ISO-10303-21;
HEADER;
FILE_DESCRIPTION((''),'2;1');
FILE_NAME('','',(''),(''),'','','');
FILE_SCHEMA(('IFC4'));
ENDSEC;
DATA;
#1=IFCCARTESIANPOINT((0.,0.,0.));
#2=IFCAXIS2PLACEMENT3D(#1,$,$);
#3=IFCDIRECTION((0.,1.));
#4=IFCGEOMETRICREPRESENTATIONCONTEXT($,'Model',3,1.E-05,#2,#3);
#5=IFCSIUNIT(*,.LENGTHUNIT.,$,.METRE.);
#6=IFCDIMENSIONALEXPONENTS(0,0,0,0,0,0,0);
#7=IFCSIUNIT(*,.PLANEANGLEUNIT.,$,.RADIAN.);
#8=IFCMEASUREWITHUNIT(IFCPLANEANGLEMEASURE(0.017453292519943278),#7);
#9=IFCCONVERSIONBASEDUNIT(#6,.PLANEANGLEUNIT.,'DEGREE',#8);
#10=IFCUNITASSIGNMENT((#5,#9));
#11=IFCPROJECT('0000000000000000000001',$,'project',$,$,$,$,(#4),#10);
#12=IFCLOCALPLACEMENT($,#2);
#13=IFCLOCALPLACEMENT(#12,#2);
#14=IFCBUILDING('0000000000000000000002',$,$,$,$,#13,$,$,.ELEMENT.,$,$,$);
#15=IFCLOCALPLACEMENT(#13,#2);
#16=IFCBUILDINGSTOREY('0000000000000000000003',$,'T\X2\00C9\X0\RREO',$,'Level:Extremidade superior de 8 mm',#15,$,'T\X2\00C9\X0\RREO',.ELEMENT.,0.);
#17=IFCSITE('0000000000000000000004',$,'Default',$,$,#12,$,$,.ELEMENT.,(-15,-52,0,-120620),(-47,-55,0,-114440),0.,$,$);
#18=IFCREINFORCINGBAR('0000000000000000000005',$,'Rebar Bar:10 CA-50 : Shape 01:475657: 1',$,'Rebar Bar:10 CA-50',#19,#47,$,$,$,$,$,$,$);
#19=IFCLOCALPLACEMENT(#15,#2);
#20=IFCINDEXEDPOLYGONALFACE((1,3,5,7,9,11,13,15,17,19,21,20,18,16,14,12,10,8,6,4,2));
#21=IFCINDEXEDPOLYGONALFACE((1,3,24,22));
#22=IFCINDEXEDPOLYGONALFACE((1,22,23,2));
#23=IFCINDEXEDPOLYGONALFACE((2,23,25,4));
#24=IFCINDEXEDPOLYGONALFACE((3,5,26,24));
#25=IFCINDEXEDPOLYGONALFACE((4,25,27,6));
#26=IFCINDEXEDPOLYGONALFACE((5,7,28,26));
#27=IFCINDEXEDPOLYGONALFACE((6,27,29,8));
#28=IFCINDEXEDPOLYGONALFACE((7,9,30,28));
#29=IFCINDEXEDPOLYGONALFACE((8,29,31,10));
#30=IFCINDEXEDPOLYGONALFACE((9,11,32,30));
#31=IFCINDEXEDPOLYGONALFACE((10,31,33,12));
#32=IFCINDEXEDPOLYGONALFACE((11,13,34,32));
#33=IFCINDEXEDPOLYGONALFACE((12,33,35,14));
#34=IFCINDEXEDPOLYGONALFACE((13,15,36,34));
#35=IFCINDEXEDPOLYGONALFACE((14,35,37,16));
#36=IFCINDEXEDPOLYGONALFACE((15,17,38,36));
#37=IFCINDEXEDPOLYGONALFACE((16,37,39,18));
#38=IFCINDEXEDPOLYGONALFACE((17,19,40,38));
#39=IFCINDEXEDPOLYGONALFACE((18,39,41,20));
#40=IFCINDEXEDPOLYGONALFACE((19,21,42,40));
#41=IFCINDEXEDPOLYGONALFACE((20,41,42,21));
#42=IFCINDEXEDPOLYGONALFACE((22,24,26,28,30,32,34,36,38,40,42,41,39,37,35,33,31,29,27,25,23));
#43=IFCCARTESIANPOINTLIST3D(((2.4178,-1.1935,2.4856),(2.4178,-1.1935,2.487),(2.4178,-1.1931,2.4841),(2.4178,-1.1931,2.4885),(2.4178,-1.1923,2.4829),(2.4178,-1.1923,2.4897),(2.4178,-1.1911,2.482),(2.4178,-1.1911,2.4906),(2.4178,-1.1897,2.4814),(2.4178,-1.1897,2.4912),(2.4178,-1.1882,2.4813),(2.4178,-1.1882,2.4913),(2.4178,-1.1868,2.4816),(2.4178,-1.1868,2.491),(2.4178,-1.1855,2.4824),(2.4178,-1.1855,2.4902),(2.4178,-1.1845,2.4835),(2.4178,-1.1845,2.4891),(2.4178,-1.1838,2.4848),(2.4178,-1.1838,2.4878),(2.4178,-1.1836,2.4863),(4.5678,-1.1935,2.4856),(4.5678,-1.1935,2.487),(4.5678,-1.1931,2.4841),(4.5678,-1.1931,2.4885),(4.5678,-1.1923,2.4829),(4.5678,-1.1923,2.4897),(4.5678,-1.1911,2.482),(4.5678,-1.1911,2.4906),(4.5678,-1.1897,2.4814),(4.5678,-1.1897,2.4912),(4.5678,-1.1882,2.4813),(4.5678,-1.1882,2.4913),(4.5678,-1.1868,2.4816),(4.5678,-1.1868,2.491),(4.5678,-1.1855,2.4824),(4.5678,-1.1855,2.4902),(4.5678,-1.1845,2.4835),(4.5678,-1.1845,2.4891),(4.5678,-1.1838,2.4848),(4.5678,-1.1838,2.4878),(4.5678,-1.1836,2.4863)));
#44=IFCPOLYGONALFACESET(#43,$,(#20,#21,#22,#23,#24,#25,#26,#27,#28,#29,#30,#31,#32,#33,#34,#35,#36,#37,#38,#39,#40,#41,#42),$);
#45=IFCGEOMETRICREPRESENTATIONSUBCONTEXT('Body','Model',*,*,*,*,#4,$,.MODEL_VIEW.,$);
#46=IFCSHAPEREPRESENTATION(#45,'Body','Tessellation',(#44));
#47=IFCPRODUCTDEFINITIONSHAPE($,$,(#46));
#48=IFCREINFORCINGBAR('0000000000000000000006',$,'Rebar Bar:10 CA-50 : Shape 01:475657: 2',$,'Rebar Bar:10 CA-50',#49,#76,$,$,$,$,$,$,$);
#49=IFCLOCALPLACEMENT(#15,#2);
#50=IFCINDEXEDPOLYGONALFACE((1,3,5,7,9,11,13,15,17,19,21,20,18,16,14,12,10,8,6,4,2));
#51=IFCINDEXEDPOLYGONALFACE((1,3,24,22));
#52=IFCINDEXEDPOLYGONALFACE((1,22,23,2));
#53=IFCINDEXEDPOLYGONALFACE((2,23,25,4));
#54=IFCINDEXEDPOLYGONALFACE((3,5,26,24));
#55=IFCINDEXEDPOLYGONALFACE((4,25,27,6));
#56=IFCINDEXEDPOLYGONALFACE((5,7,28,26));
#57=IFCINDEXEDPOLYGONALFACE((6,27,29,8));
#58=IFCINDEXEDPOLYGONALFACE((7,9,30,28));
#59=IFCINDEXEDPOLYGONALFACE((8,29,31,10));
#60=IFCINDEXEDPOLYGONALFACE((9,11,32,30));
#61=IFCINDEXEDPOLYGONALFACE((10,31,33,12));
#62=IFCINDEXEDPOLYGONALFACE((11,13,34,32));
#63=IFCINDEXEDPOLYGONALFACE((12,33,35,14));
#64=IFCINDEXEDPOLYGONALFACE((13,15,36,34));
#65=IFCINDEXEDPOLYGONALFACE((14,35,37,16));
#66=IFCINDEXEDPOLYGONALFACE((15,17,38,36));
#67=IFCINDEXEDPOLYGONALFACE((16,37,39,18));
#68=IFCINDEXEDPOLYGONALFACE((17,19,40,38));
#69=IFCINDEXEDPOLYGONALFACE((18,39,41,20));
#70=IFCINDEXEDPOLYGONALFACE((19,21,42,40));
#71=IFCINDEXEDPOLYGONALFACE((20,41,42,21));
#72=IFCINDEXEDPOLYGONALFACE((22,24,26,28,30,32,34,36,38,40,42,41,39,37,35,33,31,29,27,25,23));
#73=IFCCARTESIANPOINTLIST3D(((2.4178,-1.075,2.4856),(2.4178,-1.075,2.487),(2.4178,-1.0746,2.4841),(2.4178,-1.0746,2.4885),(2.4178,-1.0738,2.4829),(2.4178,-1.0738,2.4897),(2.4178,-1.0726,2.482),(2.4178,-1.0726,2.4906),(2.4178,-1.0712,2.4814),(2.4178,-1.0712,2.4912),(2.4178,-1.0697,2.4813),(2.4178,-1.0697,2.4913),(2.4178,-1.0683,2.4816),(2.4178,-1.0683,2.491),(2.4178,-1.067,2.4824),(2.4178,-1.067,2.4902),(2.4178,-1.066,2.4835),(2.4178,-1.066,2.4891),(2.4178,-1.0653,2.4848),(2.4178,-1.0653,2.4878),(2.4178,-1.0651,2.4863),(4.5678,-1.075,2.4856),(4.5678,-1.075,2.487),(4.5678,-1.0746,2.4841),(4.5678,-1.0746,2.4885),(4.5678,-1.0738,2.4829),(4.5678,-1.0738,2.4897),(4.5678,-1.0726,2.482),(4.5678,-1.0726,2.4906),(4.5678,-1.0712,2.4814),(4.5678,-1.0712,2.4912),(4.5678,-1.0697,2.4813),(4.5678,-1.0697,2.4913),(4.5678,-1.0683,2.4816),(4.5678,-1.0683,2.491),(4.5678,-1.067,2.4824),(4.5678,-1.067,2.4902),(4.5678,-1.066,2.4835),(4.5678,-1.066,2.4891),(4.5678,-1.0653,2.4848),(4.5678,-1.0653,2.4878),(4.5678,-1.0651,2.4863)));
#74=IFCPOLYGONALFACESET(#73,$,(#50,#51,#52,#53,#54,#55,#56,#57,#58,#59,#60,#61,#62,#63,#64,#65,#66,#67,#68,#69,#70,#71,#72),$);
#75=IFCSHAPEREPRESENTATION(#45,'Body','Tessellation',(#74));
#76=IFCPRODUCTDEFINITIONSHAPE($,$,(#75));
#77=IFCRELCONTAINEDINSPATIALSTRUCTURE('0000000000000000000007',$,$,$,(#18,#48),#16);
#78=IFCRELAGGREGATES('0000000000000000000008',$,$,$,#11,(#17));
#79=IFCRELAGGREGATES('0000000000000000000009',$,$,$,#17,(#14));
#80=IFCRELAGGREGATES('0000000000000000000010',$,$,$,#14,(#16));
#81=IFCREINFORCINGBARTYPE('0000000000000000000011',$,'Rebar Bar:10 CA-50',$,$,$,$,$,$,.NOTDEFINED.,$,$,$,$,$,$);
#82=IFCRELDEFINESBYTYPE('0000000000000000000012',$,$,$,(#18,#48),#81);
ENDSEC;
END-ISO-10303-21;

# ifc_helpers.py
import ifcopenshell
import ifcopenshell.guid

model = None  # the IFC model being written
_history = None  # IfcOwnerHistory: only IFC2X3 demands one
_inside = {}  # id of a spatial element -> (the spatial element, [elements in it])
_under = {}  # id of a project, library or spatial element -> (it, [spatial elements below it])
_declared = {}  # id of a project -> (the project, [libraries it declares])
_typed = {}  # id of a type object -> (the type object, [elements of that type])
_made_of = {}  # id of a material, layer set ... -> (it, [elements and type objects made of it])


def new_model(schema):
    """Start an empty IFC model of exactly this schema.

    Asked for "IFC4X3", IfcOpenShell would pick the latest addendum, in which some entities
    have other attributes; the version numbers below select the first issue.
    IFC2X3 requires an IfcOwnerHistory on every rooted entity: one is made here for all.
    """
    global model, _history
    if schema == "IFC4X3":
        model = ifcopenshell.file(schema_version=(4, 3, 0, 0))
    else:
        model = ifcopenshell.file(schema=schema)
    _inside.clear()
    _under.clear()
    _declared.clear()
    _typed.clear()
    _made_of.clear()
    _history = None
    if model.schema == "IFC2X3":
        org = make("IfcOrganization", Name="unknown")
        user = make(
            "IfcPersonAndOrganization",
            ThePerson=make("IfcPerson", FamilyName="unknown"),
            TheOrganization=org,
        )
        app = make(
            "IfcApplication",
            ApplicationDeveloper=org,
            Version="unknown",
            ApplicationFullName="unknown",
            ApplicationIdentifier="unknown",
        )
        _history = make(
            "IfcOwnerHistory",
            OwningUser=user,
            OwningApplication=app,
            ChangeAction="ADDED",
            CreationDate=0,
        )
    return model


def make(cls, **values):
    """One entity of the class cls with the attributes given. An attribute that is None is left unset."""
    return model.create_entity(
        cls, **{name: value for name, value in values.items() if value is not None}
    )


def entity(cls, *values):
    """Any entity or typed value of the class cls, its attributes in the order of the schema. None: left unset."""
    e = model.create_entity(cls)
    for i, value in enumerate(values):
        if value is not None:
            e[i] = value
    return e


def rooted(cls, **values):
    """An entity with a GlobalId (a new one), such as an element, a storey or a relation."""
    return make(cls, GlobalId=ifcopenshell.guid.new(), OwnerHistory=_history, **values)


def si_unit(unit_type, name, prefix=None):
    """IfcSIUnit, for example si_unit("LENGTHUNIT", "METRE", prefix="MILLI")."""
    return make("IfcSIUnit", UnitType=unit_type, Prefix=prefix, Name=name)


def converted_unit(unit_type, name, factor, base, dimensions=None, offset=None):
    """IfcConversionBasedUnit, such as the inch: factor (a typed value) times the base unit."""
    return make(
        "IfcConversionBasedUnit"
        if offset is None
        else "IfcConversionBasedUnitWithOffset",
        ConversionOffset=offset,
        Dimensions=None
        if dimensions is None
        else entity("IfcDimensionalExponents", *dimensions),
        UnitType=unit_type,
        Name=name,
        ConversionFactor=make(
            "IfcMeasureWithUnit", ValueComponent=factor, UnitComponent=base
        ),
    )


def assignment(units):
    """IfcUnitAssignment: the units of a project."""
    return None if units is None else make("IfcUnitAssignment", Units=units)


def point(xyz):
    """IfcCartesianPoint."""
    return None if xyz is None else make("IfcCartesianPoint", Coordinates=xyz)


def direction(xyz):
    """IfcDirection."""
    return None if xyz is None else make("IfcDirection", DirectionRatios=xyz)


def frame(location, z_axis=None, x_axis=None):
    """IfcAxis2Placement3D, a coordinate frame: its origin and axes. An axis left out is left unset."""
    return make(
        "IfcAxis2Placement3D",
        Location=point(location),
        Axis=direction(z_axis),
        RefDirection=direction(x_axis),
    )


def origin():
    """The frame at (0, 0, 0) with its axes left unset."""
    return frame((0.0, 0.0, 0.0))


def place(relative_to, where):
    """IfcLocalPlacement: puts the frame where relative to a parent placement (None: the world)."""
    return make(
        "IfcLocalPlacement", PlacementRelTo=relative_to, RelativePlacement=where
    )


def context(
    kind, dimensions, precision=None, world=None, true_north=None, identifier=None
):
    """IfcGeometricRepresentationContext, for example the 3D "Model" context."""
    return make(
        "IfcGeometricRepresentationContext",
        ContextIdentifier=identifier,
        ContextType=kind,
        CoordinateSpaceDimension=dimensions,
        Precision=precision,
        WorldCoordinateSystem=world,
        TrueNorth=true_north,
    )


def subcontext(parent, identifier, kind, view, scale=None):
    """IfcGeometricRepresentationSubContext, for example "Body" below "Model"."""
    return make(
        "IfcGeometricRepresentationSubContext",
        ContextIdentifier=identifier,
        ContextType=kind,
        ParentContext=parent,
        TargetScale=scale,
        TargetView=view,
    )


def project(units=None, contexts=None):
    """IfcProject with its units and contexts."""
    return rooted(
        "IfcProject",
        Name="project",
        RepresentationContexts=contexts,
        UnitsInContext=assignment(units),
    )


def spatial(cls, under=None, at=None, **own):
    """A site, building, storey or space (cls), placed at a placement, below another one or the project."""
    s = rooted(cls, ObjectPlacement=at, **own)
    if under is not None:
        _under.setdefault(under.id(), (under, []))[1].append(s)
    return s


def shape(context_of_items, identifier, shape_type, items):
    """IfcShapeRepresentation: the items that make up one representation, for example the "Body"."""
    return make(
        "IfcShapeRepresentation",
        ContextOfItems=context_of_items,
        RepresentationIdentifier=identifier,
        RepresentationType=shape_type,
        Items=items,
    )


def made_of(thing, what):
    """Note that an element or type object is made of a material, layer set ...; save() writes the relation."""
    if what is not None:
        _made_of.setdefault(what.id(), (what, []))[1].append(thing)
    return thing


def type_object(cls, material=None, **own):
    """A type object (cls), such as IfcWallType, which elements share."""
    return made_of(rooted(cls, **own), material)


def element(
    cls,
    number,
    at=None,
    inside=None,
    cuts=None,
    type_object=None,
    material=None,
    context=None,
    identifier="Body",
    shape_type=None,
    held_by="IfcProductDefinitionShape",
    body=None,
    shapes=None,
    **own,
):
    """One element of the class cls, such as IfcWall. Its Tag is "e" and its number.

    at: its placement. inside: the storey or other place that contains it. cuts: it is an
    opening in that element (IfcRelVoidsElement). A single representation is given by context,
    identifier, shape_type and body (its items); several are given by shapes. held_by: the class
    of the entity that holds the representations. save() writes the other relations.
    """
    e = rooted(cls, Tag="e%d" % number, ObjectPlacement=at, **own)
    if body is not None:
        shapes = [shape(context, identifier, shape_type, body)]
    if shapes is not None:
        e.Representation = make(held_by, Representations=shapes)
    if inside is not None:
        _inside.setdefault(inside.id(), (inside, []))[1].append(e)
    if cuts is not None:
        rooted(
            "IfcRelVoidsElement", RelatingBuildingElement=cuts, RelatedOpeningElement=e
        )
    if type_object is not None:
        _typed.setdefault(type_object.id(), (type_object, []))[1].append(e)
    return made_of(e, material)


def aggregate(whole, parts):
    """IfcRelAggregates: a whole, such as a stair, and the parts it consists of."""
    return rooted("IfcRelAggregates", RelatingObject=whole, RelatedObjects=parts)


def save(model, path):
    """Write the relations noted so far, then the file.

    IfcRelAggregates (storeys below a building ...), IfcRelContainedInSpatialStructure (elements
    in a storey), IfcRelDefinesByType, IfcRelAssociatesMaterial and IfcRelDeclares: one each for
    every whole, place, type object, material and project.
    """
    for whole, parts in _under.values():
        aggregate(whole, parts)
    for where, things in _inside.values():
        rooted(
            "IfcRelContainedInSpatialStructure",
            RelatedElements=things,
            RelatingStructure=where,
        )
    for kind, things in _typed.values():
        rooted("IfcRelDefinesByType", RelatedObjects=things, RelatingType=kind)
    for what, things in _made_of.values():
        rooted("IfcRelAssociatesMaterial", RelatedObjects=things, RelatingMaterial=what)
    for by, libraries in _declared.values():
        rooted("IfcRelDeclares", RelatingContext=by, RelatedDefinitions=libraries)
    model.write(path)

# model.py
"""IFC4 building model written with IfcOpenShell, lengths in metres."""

from ifc_helpers import new_model, entity, si_unit, converted_unit, direction, origin, place, context, subcontext, project, spatial, type_object, element, save


model = new_model("IFC4")

# Units and contexts
model_context = context("Model", 3, precision=1e-05, world=origin(), true_north=direction((0.0, 1.0)))
body_context = subcontext(model_context, "Body", "Model", "MODEL_VIEW")
ifc_project = project(units=[si_unit("LENGTHUNIT", "METRE"), converted_unit("PLANEANGLEUNIT", "DEGREE", entity("IfcPlaneAngleMeasure", 0.017453292519943278), si_unit("PLANEANGLEUNIT", "RADIAN"), dimensions=[0, 0, 0, 0, 0, 0, 0])], contexts=[model_context])

# Site, building, storey
site_placement = place(None, origin())
site = spatial("IfcSite", under=ifc_project, at=site_placement, Name="Default", CompositionType="ELEMENT", RefLatitude=(-15, -52, 0, -120620), RefLongitude=(-47, -55, 0, -114440), RefElevation=0.0)
building_placement = place(site_placement, origin())
building = spatial("IfcBuilding", under=site, at=building_placement, CompositionType="ELEMENT")
storey_placement = place(building_placement, origin())
storey = spatial("IfcBuildingStorey", under=building, at=storey_placement, Name="TÉRREO", ObjectType="Level:Extremidade superior de 8 mm", LongName="TÉRREO", CompositionType="ELEMENT", Elevation=0.0)

# Reinforcing bars
reinforcing_bar_type_1 = type_object("IfcReinforcingBarType", Name="Rebar Bar:10 CA-50", PredefinedType="NOTDEFINED")
reinforcing_bar_1_placement = place(storey_placement, origin())
element("IfcReinforcingBar", 1, at=reinforcing_bar_1_placement, inside=storey, type_object=reinforcing_bar_type_1, Name="Rebar Bar:10 CA-50 : Shape 01:475657: 1", ObjectType="Rebar Bar:10 CA-50", context=body_context, shape_type="AdvancedSweptSolid", body=[
    entity("IfcSweptDiskSolid", entity("IfcIndexedPolyCurve", entity("IfcCartesianPointList3D", [[2.4178, -1.1886, 2.4863], [4.5678, -1.1886, 2.4863]]), None, False), 0.005, None, 0.0, 1.0),
])
reinforcing_bar_2_placement = place(storey_placement, origin())
element("IfcReinforcingBar", 2, at=reinforcing_bar_2_placement, inside=storey, type_object=reinforcing_bar_type_1, Name="Rebar Bar:10 CA-50 : Shape 01:475657: 2", ObjectType="Rebar Bar:10 CA-50", context=body_context, shape_type="AdvancedSweptSolid", body=[
    entity("IfcSweptDiskSolid", entity("IfcIndexedPolyCurve", entity("IfcCartesianPointList3D", [[2.4178, -1.0701, 2.4863], [4.5678, -1.0701, 2.4863]]), None, False), 0.005, None, 0.0, 1.0),
])

save(model, "model.ifc")
